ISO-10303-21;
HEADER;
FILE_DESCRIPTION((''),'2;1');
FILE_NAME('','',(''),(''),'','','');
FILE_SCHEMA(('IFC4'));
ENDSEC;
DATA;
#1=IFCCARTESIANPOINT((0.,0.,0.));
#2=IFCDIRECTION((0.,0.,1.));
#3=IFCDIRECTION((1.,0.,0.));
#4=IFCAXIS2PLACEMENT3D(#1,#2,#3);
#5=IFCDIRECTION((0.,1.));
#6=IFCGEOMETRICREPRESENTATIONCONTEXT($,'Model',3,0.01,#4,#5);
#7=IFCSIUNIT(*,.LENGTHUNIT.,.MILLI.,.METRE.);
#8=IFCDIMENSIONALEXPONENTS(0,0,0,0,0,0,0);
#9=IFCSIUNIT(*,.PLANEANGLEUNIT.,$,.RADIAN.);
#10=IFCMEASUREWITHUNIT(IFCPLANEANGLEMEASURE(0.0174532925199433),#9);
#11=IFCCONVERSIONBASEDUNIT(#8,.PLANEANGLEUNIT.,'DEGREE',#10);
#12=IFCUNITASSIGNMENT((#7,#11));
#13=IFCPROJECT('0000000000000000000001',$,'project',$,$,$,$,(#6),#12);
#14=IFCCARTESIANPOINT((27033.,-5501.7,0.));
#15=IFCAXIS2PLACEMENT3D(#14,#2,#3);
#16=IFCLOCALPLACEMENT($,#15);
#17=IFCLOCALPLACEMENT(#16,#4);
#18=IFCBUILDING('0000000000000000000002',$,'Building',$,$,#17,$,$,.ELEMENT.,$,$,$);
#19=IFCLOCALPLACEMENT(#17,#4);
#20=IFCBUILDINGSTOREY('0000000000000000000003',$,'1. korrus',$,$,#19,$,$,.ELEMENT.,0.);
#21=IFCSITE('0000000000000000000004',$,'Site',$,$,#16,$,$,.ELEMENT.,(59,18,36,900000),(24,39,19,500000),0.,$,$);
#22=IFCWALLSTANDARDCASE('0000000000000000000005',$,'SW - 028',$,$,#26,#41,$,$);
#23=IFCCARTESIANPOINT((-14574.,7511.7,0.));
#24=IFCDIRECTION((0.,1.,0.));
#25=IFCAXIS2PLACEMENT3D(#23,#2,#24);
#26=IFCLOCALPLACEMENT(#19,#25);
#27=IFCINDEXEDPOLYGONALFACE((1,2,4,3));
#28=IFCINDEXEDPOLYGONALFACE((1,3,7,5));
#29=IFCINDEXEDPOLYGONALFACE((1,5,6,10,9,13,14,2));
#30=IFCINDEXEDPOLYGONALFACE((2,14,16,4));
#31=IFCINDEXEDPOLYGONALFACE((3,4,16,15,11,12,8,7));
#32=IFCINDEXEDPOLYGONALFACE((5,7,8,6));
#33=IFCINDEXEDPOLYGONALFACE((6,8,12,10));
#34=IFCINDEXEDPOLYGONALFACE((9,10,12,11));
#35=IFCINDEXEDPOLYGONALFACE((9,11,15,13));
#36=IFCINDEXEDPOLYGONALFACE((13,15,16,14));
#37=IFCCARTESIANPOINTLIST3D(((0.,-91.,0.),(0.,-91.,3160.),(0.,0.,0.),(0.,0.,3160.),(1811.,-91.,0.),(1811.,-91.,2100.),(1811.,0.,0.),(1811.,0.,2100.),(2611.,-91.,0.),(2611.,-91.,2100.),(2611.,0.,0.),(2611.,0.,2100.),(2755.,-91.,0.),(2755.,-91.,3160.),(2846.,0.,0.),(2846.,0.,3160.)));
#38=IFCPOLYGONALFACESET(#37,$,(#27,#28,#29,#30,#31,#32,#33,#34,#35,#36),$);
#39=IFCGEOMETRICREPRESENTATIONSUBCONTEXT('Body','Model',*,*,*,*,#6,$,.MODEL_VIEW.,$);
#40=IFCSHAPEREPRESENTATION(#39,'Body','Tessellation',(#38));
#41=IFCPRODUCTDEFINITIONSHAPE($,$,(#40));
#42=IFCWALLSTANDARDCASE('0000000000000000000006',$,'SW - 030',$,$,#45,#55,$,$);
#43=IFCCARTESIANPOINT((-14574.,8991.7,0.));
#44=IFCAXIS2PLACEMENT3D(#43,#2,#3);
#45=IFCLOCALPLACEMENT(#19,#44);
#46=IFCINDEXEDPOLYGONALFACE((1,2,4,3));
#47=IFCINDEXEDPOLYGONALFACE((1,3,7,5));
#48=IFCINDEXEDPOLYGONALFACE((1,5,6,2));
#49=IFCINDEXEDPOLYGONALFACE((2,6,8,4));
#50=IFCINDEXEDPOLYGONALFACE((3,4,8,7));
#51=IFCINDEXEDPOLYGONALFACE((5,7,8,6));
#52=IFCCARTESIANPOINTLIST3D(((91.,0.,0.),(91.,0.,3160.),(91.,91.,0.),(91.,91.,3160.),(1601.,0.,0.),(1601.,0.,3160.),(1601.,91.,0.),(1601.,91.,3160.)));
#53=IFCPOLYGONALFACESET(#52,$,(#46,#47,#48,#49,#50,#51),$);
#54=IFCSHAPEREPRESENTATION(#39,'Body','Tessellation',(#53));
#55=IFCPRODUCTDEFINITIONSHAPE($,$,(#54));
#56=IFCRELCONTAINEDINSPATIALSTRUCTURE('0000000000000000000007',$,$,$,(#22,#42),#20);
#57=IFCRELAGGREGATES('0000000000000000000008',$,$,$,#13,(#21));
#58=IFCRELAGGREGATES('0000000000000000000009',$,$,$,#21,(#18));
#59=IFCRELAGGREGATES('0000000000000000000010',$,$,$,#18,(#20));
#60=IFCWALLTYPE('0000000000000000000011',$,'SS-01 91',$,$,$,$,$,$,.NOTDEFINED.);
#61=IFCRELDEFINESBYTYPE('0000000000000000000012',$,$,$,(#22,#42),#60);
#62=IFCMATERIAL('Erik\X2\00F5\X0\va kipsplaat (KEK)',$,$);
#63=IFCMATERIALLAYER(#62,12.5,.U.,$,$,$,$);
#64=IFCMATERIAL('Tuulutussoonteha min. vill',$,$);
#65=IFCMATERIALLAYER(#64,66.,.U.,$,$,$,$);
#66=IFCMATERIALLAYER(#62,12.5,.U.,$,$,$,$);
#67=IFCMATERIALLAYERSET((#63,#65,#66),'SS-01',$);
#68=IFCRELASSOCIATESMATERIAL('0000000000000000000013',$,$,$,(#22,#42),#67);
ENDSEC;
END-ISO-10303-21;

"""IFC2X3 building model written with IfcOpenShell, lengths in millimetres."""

from ifc_helpers import new_model, entity, si_unit, converted_unit, direction, frame, origin_with_axes, origin_2d_with_axis, place, context, subcontext, project, spatial, polyline, rectangle, outline, extrude, material, layer, layer_set, layer_usage, type_object, element, save


model = new_model("IFC2X3")

# Units and contexts
model_context = context("Model", 3, precision=0.01, world=origin_with_axes(), true_north=direction((0.0, 1.0)))
body_context = subcontext(model_context, "Body", "Model", "MODEL_VIEW")
ifc_project = project(units=[si_unit("LENGTHUNIT", "METRE", prefix="MILLI"), converted_unit("PLANEANGLEUNIT", "DEGREE", entity("IfcPlaneAngleMeasure", 0.0174532925199433), si_unit("PLANEANGLEUNIT", "RADIAN"), dimensions=[0, 0, 0, 0, 0, 0, 0])], contexts=[model_context])

# Site, building, storey
site_placement = place(None, frame((27033.0, -5501.7, 0.0), z_axis=(0.0, 0.0, 1.0), x_axis=(1.0, 0.0, 0.0)))
site = spatial("IfcSite", under=ifc_project, at=site_placement, Name="Site", CompositionType="ELEMENT", RefLatitude=(59, 18, 36, 900000), RefLongitude=(24, 39, 19, 500000), RefElevation=0.0)
building_placement = place(site_placement, origin_with_axes())
building = spatial("IfcBuilding", under=site, at=building_placement, Name="Building", CompositionType="ELEMENT")
storey_placement = place(building_placement, origin_with_axes())
storey = spatial("IfcBuildingStorey", under=building, at=storey_placement, Name="1. korrus", CompositionType="ELEMENT", Elevation=0.0)

# Wall, opening
ifc_material_1 = material(Name="Erikõva kipsplaat (KEK)")
ifc_layer_1 = layer(ifc_material_1, 12.5, ventilated="UNKNOWN")
ifc_material_2 = material(Name="Tuulutussoonteha min. vill")
ifc_layer_2 = layer(ifc_material_2, 66.0, ventilated="UNKNOWN")
ifc_layer_3 = layer(ifc_material_1, 12.5, ventilated="UNKNOWN")
ifc_layer_set_1 = layer_set([ifc_layer_1, ifc_layer_2, ifc_layer_3], Name="SS-01")
ifc_layer_usage_1 = layer_usage(ifc_layer_set_1, "AXIS2", "POSITIVE", -91.0)
wall_type_1 = type_object("IfcWallType", Name="SS-01 91", PredefinedType="NOTDEFINED")
wall_1_placement = place(storey_placement, frame((-14574.0, 7511.7, 0.0), z_axis=(0.0, 0.0, 1.0), x_axis=(0.0, 1.0, 0.0)))
wall_1 = element("IfcWallStandardCase", 1, at=wall_1_placement, inside=storey, type_object=wall_type_1, material=ifc_layer_usage_1, Name="SW - 028", context=body_context, shape_type="SweptSolid", body=[
    extrude(outline(polyline([(0.0, -91.0), (2755.0, -91.0), (2846.0, 0.0), (0.0, 0.0), (0.0, -91.0)])), origin_with_axes(), (0.0, 0.0, 1.0), 3160.0),
])
opening_1_placement = place(wall_1_placement, frame((2211.0, 0.0, 0.0), z_axis=(0.0, 0.0, 1.0), x_axis=(1.0, 0.0, 0.0)))
element("IfcOpeningElement", 2, at=opening_1_placement, cuts=wall_1, context=body_context, shape_type="SweptSolid", body=[
    extrude(rectangle(XDim=800.0, YDim=2100.0, at=origin_2d_with_axis()), frame((0.0, -91.0, 1050.0), z_axis=(0.0, -1.0, 0.0), x_axis=(-1.0, 0.0, 0.0)), (0.0, 0.0, -1.0), 273.0),
    extrude(rectangle(XDim=874.0, YDim=2137.0, at=origin_2d_with_axis()), frame((0.0, 0.0, 1068.5), z_axis=(0.0, 1.0, 0.0), x_axis=(-1.0, 0.0, 0.0)), (0.0, 0.0, 1.0), 91.0),
])

# Wall
ifc_layer_usage_2 = layer_usage(ifc_layer_set_1, "AXIS2", "NEGATIVE", 91.0)
wall_2_placement = place(storey_placement, frame((-14574.0, 8991.7, 0.0), z_axis=(0.0, 0.0, 1.0), x_axis=(1.0, 0.0, 0.0)))
element("IfcWallStandardCase", 3, at=wall_2_placement, inside=storey, type_object=wall_type_1, material=ifc_layer_usage_2, Name="SW - 030", context=body_context, shape_type="SweptSolid", body=[
    extrude(outline(polyline([(91.0, 0.0), (1601.0, 0.0), (1601.0, 91.0), (91.0, 91.0), (91.0, 0.0)])), origin_with_axes(), (0.0, 0.0, 1.0), 3160.0),
])

save(model, "model.ifc")
